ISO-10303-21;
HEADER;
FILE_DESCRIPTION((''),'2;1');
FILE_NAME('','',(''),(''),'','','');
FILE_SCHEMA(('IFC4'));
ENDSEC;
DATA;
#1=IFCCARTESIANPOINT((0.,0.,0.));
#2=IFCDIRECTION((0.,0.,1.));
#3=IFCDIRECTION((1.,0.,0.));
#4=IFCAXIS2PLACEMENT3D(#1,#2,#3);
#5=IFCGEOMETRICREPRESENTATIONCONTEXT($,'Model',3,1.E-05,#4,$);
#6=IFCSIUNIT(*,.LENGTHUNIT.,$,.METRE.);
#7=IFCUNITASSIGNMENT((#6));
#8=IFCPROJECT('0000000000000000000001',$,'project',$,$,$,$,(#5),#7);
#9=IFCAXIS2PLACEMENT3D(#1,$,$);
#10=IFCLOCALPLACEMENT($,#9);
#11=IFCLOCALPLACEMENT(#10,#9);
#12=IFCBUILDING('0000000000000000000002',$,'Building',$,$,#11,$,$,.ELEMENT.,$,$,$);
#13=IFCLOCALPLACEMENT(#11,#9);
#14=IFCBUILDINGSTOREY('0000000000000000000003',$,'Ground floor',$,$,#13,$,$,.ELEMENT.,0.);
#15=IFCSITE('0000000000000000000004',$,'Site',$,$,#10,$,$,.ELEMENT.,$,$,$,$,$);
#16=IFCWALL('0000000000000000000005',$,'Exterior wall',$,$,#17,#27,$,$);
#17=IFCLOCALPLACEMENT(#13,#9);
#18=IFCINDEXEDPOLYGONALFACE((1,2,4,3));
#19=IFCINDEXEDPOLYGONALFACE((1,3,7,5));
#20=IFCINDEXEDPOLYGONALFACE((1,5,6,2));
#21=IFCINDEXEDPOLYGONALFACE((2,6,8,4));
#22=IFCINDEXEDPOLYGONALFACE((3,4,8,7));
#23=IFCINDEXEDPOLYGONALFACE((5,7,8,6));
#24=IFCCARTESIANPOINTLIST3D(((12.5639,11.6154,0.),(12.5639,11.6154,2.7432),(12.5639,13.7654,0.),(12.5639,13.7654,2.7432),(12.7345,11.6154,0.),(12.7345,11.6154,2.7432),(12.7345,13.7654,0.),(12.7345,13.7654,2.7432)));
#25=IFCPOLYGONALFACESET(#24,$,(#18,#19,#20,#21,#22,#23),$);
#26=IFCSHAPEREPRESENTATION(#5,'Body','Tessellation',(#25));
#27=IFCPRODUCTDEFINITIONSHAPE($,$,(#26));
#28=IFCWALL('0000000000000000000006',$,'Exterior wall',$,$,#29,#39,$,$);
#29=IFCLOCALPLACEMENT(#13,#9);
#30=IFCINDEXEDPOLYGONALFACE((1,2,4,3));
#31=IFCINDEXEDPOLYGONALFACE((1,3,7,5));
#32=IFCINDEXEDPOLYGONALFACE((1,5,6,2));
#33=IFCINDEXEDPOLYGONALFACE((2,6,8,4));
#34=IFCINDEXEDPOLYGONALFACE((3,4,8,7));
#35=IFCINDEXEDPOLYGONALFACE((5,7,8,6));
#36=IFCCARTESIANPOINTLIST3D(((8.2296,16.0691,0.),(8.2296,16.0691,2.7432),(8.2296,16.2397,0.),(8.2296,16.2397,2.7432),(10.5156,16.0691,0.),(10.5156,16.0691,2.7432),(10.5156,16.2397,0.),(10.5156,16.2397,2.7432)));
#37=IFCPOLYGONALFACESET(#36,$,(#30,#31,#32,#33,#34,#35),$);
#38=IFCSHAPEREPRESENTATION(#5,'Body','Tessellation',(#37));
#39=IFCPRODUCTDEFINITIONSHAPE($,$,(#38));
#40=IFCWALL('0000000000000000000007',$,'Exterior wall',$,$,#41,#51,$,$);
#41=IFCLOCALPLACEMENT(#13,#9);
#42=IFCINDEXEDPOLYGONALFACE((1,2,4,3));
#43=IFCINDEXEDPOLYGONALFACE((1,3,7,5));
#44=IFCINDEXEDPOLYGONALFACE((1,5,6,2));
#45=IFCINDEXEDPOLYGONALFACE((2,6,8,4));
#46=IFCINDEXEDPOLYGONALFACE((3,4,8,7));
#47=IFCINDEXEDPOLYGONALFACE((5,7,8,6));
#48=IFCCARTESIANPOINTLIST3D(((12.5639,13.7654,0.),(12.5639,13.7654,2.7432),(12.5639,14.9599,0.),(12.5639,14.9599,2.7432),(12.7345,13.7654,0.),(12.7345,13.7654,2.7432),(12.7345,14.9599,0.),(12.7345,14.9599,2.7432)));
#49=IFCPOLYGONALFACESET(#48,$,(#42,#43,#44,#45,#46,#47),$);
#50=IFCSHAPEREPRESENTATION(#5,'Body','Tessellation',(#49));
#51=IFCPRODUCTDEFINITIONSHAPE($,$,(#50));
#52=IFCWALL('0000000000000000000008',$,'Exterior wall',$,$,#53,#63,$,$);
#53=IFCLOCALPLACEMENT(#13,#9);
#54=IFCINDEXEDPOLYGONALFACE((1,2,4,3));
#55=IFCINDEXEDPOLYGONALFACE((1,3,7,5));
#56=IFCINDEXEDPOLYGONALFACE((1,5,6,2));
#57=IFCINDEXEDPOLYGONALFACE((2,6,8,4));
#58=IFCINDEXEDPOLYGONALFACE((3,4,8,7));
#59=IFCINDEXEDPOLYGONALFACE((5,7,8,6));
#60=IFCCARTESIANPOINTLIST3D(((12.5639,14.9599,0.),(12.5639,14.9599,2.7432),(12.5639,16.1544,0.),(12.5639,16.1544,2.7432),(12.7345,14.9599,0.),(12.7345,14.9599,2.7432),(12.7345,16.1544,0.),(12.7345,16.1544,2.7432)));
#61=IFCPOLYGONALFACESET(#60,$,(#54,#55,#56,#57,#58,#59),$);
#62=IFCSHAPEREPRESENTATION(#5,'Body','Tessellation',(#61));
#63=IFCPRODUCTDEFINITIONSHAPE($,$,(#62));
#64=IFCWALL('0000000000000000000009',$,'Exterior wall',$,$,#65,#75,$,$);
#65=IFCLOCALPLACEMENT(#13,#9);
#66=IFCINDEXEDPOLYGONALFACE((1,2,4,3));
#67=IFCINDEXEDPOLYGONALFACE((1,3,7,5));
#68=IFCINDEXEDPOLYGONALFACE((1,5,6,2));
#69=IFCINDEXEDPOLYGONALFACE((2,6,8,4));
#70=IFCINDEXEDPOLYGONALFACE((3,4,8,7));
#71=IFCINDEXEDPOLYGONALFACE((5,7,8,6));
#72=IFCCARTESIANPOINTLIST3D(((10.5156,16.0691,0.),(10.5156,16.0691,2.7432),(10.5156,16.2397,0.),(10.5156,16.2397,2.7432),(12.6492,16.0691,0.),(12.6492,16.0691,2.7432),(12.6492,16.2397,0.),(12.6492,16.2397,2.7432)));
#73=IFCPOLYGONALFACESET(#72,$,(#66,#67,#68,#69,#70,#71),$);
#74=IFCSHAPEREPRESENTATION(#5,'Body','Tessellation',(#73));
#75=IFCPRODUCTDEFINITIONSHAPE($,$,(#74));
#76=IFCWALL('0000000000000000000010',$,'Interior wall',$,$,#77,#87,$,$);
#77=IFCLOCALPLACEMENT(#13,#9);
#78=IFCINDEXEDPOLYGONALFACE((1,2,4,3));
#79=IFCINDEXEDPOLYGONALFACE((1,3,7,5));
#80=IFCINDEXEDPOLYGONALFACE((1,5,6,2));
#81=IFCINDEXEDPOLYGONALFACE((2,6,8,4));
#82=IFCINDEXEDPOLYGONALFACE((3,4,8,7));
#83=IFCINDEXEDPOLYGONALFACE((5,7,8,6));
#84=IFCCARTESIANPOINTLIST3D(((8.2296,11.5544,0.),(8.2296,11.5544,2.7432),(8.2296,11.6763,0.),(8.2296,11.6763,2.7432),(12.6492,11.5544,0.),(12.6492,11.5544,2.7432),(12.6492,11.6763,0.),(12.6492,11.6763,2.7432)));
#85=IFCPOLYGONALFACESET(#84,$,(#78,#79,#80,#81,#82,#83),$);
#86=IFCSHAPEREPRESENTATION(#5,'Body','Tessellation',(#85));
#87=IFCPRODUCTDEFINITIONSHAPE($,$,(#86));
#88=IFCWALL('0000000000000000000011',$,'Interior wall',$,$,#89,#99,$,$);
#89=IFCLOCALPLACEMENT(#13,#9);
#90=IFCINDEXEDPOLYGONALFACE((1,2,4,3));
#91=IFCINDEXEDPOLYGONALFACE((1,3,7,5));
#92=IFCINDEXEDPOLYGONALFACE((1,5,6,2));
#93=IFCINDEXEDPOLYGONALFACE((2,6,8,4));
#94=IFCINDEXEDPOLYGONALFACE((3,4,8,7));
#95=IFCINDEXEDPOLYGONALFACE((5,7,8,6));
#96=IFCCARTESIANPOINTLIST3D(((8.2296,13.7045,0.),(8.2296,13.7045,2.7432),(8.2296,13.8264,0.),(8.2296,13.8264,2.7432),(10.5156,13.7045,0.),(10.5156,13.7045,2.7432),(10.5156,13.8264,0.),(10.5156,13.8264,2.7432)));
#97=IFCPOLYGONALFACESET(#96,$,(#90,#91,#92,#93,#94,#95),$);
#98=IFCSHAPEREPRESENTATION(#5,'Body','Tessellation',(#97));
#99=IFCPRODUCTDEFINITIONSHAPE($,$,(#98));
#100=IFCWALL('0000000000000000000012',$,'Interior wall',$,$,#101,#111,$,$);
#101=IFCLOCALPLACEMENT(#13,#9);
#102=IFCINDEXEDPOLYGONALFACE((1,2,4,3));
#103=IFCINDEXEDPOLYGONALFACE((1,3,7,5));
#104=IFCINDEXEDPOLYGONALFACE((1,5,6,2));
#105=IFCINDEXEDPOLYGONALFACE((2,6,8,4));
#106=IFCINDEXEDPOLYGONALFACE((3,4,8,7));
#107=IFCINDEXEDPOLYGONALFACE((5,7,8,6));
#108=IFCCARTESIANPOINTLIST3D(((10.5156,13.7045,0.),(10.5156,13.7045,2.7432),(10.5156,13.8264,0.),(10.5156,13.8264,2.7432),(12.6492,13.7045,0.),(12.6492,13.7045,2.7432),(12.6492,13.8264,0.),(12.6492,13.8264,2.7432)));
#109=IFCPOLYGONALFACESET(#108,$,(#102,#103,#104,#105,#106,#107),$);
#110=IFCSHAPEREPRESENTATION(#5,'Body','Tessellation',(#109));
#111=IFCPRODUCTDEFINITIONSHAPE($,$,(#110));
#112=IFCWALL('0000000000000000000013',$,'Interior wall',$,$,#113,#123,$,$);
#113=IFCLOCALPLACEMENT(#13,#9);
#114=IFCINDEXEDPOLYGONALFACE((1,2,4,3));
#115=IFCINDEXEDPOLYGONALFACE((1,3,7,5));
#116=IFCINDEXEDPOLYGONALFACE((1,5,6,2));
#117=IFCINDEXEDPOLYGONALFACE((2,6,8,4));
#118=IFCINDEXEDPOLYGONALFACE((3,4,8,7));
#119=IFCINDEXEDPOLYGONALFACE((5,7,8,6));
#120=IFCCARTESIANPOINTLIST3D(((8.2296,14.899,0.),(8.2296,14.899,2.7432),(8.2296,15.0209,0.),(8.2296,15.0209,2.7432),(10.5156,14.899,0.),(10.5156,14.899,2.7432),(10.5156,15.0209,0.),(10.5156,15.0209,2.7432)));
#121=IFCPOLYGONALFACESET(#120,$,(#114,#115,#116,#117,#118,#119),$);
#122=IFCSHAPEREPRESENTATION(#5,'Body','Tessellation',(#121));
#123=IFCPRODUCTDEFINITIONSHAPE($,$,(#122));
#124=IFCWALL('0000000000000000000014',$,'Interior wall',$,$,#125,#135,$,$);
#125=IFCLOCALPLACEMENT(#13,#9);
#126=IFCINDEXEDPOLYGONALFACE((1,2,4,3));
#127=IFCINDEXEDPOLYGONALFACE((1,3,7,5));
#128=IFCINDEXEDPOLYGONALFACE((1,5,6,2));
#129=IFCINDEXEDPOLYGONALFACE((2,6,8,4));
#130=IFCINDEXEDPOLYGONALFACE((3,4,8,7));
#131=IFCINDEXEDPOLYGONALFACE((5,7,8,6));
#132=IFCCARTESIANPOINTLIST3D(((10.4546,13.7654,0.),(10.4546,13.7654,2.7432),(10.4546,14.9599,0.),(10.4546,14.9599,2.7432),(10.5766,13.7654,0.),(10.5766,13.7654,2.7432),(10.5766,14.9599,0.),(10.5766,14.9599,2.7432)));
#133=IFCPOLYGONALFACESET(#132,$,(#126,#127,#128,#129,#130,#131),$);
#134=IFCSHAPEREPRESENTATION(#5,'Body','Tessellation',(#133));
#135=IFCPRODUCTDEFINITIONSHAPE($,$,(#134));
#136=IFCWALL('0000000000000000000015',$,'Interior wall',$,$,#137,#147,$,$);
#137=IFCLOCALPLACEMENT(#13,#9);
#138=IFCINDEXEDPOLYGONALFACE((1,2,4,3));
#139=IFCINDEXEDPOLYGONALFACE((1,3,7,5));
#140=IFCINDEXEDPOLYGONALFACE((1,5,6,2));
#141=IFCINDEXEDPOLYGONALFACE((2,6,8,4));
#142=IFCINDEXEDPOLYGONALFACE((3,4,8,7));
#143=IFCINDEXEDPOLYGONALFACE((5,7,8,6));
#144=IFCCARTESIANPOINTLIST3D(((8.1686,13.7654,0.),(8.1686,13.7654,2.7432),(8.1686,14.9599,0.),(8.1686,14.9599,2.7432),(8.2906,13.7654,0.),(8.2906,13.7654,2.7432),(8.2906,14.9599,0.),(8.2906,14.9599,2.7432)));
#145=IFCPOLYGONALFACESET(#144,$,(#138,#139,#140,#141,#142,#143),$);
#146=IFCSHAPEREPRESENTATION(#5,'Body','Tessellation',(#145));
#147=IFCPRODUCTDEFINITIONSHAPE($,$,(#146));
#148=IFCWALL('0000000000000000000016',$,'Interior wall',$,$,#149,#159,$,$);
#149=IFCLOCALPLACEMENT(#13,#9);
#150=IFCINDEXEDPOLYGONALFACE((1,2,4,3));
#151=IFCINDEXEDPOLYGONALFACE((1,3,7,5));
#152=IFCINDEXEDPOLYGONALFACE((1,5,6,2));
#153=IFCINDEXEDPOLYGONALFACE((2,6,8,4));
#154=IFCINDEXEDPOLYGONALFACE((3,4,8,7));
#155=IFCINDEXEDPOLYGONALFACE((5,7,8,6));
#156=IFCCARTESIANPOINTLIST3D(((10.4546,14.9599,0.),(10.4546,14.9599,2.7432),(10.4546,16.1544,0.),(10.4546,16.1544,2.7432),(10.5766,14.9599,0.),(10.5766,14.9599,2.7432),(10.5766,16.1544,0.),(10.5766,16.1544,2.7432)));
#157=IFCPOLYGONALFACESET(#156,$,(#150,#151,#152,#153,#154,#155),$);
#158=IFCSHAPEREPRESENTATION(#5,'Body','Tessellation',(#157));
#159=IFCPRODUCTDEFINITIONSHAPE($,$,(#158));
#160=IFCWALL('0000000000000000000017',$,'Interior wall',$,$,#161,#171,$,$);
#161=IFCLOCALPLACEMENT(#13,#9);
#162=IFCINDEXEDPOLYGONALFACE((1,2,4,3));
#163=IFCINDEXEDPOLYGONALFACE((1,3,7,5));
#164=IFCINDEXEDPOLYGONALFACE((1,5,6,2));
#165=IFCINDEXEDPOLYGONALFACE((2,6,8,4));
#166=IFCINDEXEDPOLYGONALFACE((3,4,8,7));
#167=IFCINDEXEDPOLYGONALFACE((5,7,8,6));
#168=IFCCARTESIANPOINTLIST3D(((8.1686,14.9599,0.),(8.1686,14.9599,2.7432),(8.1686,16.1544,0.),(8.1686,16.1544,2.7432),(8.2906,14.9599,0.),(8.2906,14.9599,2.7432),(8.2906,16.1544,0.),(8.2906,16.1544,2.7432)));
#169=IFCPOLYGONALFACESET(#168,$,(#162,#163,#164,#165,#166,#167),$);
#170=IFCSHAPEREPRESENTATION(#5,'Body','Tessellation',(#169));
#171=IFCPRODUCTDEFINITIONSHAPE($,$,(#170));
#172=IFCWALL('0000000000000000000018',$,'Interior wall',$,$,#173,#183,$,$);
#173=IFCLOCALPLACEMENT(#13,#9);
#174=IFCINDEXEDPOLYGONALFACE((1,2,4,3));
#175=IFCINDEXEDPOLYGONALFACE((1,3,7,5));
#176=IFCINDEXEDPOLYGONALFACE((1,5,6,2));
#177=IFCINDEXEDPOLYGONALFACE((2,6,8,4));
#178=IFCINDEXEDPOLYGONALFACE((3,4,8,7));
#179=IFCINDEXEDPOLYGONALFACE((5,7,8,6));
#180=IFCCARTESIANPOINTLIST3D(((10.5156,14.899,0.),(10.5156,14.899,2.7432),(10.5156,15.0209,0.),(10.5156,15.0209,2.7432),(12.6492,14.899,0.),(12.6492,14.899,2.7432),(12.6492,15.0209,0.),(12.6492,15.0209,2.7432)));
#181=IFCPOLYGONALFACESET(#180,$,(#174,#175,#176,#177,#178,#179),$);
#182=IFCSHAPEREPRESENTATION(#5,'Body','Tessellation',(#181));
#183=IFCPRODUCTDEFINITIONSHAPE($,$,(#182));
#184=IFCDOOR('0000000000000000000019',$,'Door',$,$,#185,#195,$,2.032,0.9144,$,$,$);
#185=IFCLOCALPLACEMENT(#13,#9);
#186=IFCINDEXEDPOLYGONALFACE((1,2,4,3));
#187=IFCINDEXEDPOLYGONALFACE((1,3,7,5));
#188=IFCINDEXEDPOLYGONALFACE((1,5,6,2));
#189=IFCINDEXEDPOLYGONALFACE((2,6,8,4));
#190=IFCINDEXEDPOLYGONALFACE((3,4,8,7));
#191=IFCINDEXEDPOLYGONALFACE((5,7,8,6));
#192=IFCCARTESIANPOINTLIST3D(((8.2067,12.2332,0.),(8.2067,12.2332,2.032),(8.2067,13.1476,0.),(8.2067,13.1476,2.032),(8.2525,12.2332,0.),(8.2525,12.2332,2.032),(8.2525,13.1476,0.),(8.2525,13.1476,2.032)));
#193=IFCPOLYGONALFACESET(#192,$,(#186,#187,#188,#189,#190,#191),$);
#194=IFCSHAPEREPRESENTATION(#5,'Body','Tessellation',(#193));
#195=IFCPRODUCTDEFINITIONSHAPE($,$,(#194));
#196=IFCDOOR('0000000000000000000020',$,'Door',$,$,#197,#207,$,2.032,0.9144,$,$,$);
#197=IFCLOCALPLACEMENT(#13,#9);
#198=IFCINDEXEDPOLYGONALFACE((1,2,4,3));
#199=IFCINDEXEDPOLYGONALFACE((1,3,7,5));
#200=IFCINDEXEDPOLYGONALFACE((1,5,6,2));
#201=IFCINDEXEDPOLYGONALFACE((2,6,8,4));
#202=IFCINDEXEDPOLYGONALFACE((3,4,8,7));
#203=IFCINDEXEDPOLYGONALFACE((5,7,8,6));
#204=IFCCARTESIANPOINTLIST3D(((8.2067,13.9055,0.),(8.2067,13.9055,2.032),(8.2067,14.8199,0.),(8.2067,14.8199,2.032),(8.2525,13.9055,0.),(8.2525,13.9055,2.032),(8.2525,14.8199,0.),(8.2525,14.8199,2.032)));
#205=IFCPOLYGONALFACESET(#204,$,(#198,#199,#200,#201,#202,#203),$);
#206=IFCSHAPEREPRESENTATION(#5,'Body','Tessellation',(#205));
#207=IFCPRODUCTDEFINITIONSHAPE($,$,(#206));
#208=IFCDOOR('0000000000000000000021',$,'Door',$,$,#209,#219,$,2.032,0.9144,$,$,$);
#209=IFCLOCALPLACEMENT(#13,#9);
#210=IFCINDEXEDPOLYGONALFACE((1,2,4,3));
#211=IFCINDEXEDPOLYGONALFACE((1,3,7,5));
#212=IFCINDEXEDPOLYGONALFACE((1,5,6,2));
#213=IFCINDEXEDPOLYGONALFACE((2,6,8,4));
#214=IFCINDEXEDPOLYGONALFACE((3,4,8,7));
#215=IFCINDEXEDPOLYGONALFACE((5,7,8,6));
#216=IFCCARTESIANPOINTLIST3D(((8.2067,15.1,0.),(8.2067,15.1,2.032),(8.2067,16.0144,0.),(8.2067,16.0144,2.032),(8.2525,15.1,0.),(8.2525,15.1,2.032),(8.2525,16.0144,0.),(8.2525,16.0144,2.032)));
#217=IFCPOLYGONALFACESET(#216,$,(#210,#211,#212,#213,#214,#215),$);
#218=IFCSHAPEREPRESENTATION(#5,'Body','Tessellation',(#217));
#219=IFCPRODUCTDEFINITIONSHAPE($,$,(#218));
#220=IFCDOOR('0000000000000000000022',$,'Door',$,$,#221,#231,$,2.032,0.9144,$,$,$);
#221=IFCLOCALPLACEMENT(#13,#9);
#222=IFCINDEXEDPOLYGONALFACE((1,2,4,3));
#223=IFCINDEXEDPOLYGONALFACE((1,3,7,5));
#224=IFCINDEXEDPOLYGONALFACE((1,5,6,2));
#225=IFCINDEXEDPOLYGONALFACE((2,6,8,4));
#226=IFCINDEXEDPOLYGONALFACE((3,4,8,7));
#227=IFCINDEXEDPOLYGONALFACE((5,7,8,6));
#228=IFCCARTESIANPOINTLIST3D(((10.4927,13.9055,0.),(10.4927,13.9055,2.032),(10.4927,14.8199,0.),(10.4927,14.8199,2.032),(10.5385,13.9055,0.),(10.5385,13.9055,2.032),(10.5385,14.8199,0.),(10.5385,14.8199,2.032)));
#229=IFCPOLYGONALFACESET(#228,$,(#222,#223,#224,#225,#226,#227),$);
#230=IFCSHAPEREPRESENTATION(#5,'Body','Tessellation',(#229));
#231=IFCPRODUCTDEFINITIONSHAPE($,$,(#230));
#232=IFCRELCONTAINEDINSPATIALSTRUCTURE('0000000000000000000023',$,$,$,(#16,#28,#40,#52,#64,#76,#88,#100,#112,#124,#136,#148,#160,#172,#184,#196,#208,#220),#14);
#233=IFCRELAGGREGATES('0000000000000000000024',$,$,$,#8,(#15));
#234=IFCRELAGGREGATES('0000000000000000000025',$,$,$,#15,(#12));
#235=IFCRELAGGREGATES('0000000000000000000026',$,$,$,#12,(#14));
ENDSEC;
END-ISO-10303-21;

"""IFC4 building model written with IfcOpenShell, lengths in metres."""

from ifc_helpers import new_model, si_unit, frame, origin, origin_with_axes, origin_2d, place, context, project, spatial, rectangle, extrude, element, save


model = new_model("IFC4")

# Units and contexts
model_context = context("Model", 3, precision=1e-05, world=origin_with_axes())
ifc_project = project(units=[si_unit("LENGTHUNIT", "METRE")], contexts=[model_context])

# Site, building, storey
site_placement = place(None, origin())
site = spatial("IfcSite", under=ifc_project, at=site_placement, Name="Site", CompositionType="ELEMENT")
building_placement = place(site_placement, origin())
building = spatial("IfcBuilding", under=site, at=building_placement, Name="Building", CompositionType="ELEMENT")
storey_placement = place(building_placement, origin())
storey = spatial("IfcBuildingStorey", under=building, at=storey_placement, Name="Ground floor", CompositionType="ELEMENT", Elevation=0.0)

# Walls
wall_1_placement = place(storey_placement, frame((12.6492, 12.6904, 0.0), x_axis=(0.0, 1.0, 0.0)))
element("IfcWall", 1, at=wall_1_placement, inside=storey, Name="Exterior wall", context=model_context, shape_type="SweptSolid", body=[
    extrude(rectangle(XDim=2.1501, YDim=0.1707, at=origin_2d()), origin(), (0.0, 0.0, 1.0), 2.7432),
])
wall_2_placement = place(storey_placement, frame((9.3726, 16.1544, 0.0), x_axis=(1.0, 0.0, 0.0)))
element("IfcWall", 2, at=wall_2_placement, inside=storey, Name="Exterior wall", context=model_context, shape_type="SweptSolid", body=[
    extrude(rectangle(XDim=2.286, YDim=0.1707, at=origin_2d()), origin(), (0.0, 0.0, 1.0), 2.7432),
])
for number, where, x_axis, name in (
    (3, (12.6492, 14.3627, 0.0), (0.0, 1.0, 0.0), "Exterior wall"),
    (4, (12.6492, 15.5572, 0.0), (0.0, 1.0, 0.0), "Exterior wall"),
):
    element("IfcWall", number, at=place(storey_placement, frame(where, x_axis=x_axis)), inside=storey, Name=name, context=model_context, shape_type="SweptSolid", body=[
        extrude(rectangle(XDim=1.1945, YDim=0.1707, at=origin_2d()), origin(), (0.0, 0.0, 1.0), 2.7432),
    ])
wall_3_placement = place(storey_placement, frame((11.5824, 16.1544, 0.0), x_axis=(1.0, 0.0, 0.0)))
element("IfcWall", 5, at=wall_3_placement, inside=storey, Name="Exterior wall", context=model_context, shape_type="SweptSolid", body=[
    extrude(rectangle(XDim=2.1336, YDim=0.1707, at=origin_2d()), origin(), (0.0, 0.0, 1.0), 2.7432),
])
wall_4_placement = place(storey_placement, frame((10.4394, 11.6154, 0.0), x_axis=(1.0, 0.0, 0.0)))
element("IfcWall", 6, at=wall_4_placement, inside=storey, Name="Interior wall", context=model_context, shape_type="SweptSolid", body=[
    extrude(rectangle(XDim=4.4196, YDim=0.1219, at=origin_2d()), origin(), (0.0, 0.0, 1.0), 2.7432),
])
wall_5_placement = place(storey_placement, frame((9.3726, 13.7654, 0.0), x_axis=(1.0, 0.0, 0.0)))
element("IfcWall", 7, at=wall_5_placement, inside=storey, Name="Interior wall", context=model_context, shape_type="SweptSolid", body=[
    extrude(rectangle(XDim=2.286, YDim=0.1219, at=origin_2d()), origin(), (0.0, 0.0, 1.0), 2.7432),
])
wall_6_placement = place(storey_placement, frame((11.5824, 13.7654, 0.0), x_axis=(1.0, 0.0, 0.0)))
element("IfcWall", 8, at=wall_6_placement, inside=storey, Name="Interior wall", context=model_context, shape_type="SweptSolid", body=[
    extrude(rectangle(XDim=2.1336, YDim=0.1219, at=origin_2d()), origin(), (0.0, 0.0, 1.0), 2.7432),
])
wall_7_placement = place(storey_placement, frame((9.3726, 14.9599, 0.0), x_axis=(1.0, 0.0, 0.0)))
element("IfcWall", 9, at=wall_7_placement, inside=storey, Name="Interior wall", context=model_context, shape_type="SweptSolid", body=[
    extrude(rectangle(XDim=2.286, YDim=0.1219, at=origin_2d()), origin(), (0.0, 0.0, 1.0), 2.7432),
])
for number, where, x_axis, name in (
    (10, (10.5156, 14.3627, 0.0), (0.0, 1.0, 0.0), "Interior wall"),
    (11, (8.2296, 14.3627, 0.0), (0.0, 1.0, 0.0), "Interior wall"),
    (12, (10.5156, 15.5572, 0.0), (0.0, 1.0, 0.0), "Interior wall"),
):
    element("IfcWall", number, at=place(storey_placement, frame(where, x_axis=x_axis)), inside=storey, Name=name, context=model_context, shape_type="SweptSolid", body=[
        extrude(rectangle(XDim=1.1945, YDim=0.1219, at=origin_2d()), origin(), (0.0, 0.0, 1.0), 2.7432),
    ])
wall_8_placement = place(storey_placement, frame((8.2296, 15.5572, 0.0), x_axis=(0.0, 1.0, 0.0)))
element("IfcWall", 13, at=wall_8_placement, inside=storey, Name="Interior wall", context=model_context, shape_type="SweptSolid", body=[
    extrude(rectangle(XDim=1.1945, YDim=0.1219, at=origin_2d()), origin(), (0.0, 0.0, 1.0), 2.7432),
])
wall_9_placement = place(storey_placement, frame((11.5824, 14.9599, 0.0), x_axis=(1.0, 0.0, 0.0)))
element("IfcWall", 14, at=wall_9_placement, inside=storey, Name="Interior wall", context=model_context, shape_type="SweptSolid", body=[
    extrude(rectangle(XDim=2.1336, YDim=0.1219, at=origin_2d()), origin(), (0.0, 0.0, 1.0), 2.7432),
])

# Doors
for number, where, x_axis, name in (
    (15, (8.2296, 12.6904, 0.0), (0.0, 1.0, 0.0), "Door"),
    (16, (8.2296, 14.3627, 0.0), (0.0, 1.0, 0.0), "Door"),
    (17, (8.2296, 15.5572, 0.0), (0.0, 1.0, 0.0), "Door"),
    (18, (10.5156, 14.3627, 0.0), (0.0, 1.0, 0.0), "Door"),
):
    element("IfcDoor", number, at=place(storey_placement, frame(where, x_axis=x_axis)), inside=storey, Name=name, OverallHeight=2.032, OverallWidth=0.9144, context=model_context, shape_type="SweptSolid", body=[
        extrude(rectangle(XDim=0.9144, YDim=0.0457, at=origin_2d()), origin(), (0.0, 0.0, 1.0), 2.032),
    ])

save(model, "model.ifc")
